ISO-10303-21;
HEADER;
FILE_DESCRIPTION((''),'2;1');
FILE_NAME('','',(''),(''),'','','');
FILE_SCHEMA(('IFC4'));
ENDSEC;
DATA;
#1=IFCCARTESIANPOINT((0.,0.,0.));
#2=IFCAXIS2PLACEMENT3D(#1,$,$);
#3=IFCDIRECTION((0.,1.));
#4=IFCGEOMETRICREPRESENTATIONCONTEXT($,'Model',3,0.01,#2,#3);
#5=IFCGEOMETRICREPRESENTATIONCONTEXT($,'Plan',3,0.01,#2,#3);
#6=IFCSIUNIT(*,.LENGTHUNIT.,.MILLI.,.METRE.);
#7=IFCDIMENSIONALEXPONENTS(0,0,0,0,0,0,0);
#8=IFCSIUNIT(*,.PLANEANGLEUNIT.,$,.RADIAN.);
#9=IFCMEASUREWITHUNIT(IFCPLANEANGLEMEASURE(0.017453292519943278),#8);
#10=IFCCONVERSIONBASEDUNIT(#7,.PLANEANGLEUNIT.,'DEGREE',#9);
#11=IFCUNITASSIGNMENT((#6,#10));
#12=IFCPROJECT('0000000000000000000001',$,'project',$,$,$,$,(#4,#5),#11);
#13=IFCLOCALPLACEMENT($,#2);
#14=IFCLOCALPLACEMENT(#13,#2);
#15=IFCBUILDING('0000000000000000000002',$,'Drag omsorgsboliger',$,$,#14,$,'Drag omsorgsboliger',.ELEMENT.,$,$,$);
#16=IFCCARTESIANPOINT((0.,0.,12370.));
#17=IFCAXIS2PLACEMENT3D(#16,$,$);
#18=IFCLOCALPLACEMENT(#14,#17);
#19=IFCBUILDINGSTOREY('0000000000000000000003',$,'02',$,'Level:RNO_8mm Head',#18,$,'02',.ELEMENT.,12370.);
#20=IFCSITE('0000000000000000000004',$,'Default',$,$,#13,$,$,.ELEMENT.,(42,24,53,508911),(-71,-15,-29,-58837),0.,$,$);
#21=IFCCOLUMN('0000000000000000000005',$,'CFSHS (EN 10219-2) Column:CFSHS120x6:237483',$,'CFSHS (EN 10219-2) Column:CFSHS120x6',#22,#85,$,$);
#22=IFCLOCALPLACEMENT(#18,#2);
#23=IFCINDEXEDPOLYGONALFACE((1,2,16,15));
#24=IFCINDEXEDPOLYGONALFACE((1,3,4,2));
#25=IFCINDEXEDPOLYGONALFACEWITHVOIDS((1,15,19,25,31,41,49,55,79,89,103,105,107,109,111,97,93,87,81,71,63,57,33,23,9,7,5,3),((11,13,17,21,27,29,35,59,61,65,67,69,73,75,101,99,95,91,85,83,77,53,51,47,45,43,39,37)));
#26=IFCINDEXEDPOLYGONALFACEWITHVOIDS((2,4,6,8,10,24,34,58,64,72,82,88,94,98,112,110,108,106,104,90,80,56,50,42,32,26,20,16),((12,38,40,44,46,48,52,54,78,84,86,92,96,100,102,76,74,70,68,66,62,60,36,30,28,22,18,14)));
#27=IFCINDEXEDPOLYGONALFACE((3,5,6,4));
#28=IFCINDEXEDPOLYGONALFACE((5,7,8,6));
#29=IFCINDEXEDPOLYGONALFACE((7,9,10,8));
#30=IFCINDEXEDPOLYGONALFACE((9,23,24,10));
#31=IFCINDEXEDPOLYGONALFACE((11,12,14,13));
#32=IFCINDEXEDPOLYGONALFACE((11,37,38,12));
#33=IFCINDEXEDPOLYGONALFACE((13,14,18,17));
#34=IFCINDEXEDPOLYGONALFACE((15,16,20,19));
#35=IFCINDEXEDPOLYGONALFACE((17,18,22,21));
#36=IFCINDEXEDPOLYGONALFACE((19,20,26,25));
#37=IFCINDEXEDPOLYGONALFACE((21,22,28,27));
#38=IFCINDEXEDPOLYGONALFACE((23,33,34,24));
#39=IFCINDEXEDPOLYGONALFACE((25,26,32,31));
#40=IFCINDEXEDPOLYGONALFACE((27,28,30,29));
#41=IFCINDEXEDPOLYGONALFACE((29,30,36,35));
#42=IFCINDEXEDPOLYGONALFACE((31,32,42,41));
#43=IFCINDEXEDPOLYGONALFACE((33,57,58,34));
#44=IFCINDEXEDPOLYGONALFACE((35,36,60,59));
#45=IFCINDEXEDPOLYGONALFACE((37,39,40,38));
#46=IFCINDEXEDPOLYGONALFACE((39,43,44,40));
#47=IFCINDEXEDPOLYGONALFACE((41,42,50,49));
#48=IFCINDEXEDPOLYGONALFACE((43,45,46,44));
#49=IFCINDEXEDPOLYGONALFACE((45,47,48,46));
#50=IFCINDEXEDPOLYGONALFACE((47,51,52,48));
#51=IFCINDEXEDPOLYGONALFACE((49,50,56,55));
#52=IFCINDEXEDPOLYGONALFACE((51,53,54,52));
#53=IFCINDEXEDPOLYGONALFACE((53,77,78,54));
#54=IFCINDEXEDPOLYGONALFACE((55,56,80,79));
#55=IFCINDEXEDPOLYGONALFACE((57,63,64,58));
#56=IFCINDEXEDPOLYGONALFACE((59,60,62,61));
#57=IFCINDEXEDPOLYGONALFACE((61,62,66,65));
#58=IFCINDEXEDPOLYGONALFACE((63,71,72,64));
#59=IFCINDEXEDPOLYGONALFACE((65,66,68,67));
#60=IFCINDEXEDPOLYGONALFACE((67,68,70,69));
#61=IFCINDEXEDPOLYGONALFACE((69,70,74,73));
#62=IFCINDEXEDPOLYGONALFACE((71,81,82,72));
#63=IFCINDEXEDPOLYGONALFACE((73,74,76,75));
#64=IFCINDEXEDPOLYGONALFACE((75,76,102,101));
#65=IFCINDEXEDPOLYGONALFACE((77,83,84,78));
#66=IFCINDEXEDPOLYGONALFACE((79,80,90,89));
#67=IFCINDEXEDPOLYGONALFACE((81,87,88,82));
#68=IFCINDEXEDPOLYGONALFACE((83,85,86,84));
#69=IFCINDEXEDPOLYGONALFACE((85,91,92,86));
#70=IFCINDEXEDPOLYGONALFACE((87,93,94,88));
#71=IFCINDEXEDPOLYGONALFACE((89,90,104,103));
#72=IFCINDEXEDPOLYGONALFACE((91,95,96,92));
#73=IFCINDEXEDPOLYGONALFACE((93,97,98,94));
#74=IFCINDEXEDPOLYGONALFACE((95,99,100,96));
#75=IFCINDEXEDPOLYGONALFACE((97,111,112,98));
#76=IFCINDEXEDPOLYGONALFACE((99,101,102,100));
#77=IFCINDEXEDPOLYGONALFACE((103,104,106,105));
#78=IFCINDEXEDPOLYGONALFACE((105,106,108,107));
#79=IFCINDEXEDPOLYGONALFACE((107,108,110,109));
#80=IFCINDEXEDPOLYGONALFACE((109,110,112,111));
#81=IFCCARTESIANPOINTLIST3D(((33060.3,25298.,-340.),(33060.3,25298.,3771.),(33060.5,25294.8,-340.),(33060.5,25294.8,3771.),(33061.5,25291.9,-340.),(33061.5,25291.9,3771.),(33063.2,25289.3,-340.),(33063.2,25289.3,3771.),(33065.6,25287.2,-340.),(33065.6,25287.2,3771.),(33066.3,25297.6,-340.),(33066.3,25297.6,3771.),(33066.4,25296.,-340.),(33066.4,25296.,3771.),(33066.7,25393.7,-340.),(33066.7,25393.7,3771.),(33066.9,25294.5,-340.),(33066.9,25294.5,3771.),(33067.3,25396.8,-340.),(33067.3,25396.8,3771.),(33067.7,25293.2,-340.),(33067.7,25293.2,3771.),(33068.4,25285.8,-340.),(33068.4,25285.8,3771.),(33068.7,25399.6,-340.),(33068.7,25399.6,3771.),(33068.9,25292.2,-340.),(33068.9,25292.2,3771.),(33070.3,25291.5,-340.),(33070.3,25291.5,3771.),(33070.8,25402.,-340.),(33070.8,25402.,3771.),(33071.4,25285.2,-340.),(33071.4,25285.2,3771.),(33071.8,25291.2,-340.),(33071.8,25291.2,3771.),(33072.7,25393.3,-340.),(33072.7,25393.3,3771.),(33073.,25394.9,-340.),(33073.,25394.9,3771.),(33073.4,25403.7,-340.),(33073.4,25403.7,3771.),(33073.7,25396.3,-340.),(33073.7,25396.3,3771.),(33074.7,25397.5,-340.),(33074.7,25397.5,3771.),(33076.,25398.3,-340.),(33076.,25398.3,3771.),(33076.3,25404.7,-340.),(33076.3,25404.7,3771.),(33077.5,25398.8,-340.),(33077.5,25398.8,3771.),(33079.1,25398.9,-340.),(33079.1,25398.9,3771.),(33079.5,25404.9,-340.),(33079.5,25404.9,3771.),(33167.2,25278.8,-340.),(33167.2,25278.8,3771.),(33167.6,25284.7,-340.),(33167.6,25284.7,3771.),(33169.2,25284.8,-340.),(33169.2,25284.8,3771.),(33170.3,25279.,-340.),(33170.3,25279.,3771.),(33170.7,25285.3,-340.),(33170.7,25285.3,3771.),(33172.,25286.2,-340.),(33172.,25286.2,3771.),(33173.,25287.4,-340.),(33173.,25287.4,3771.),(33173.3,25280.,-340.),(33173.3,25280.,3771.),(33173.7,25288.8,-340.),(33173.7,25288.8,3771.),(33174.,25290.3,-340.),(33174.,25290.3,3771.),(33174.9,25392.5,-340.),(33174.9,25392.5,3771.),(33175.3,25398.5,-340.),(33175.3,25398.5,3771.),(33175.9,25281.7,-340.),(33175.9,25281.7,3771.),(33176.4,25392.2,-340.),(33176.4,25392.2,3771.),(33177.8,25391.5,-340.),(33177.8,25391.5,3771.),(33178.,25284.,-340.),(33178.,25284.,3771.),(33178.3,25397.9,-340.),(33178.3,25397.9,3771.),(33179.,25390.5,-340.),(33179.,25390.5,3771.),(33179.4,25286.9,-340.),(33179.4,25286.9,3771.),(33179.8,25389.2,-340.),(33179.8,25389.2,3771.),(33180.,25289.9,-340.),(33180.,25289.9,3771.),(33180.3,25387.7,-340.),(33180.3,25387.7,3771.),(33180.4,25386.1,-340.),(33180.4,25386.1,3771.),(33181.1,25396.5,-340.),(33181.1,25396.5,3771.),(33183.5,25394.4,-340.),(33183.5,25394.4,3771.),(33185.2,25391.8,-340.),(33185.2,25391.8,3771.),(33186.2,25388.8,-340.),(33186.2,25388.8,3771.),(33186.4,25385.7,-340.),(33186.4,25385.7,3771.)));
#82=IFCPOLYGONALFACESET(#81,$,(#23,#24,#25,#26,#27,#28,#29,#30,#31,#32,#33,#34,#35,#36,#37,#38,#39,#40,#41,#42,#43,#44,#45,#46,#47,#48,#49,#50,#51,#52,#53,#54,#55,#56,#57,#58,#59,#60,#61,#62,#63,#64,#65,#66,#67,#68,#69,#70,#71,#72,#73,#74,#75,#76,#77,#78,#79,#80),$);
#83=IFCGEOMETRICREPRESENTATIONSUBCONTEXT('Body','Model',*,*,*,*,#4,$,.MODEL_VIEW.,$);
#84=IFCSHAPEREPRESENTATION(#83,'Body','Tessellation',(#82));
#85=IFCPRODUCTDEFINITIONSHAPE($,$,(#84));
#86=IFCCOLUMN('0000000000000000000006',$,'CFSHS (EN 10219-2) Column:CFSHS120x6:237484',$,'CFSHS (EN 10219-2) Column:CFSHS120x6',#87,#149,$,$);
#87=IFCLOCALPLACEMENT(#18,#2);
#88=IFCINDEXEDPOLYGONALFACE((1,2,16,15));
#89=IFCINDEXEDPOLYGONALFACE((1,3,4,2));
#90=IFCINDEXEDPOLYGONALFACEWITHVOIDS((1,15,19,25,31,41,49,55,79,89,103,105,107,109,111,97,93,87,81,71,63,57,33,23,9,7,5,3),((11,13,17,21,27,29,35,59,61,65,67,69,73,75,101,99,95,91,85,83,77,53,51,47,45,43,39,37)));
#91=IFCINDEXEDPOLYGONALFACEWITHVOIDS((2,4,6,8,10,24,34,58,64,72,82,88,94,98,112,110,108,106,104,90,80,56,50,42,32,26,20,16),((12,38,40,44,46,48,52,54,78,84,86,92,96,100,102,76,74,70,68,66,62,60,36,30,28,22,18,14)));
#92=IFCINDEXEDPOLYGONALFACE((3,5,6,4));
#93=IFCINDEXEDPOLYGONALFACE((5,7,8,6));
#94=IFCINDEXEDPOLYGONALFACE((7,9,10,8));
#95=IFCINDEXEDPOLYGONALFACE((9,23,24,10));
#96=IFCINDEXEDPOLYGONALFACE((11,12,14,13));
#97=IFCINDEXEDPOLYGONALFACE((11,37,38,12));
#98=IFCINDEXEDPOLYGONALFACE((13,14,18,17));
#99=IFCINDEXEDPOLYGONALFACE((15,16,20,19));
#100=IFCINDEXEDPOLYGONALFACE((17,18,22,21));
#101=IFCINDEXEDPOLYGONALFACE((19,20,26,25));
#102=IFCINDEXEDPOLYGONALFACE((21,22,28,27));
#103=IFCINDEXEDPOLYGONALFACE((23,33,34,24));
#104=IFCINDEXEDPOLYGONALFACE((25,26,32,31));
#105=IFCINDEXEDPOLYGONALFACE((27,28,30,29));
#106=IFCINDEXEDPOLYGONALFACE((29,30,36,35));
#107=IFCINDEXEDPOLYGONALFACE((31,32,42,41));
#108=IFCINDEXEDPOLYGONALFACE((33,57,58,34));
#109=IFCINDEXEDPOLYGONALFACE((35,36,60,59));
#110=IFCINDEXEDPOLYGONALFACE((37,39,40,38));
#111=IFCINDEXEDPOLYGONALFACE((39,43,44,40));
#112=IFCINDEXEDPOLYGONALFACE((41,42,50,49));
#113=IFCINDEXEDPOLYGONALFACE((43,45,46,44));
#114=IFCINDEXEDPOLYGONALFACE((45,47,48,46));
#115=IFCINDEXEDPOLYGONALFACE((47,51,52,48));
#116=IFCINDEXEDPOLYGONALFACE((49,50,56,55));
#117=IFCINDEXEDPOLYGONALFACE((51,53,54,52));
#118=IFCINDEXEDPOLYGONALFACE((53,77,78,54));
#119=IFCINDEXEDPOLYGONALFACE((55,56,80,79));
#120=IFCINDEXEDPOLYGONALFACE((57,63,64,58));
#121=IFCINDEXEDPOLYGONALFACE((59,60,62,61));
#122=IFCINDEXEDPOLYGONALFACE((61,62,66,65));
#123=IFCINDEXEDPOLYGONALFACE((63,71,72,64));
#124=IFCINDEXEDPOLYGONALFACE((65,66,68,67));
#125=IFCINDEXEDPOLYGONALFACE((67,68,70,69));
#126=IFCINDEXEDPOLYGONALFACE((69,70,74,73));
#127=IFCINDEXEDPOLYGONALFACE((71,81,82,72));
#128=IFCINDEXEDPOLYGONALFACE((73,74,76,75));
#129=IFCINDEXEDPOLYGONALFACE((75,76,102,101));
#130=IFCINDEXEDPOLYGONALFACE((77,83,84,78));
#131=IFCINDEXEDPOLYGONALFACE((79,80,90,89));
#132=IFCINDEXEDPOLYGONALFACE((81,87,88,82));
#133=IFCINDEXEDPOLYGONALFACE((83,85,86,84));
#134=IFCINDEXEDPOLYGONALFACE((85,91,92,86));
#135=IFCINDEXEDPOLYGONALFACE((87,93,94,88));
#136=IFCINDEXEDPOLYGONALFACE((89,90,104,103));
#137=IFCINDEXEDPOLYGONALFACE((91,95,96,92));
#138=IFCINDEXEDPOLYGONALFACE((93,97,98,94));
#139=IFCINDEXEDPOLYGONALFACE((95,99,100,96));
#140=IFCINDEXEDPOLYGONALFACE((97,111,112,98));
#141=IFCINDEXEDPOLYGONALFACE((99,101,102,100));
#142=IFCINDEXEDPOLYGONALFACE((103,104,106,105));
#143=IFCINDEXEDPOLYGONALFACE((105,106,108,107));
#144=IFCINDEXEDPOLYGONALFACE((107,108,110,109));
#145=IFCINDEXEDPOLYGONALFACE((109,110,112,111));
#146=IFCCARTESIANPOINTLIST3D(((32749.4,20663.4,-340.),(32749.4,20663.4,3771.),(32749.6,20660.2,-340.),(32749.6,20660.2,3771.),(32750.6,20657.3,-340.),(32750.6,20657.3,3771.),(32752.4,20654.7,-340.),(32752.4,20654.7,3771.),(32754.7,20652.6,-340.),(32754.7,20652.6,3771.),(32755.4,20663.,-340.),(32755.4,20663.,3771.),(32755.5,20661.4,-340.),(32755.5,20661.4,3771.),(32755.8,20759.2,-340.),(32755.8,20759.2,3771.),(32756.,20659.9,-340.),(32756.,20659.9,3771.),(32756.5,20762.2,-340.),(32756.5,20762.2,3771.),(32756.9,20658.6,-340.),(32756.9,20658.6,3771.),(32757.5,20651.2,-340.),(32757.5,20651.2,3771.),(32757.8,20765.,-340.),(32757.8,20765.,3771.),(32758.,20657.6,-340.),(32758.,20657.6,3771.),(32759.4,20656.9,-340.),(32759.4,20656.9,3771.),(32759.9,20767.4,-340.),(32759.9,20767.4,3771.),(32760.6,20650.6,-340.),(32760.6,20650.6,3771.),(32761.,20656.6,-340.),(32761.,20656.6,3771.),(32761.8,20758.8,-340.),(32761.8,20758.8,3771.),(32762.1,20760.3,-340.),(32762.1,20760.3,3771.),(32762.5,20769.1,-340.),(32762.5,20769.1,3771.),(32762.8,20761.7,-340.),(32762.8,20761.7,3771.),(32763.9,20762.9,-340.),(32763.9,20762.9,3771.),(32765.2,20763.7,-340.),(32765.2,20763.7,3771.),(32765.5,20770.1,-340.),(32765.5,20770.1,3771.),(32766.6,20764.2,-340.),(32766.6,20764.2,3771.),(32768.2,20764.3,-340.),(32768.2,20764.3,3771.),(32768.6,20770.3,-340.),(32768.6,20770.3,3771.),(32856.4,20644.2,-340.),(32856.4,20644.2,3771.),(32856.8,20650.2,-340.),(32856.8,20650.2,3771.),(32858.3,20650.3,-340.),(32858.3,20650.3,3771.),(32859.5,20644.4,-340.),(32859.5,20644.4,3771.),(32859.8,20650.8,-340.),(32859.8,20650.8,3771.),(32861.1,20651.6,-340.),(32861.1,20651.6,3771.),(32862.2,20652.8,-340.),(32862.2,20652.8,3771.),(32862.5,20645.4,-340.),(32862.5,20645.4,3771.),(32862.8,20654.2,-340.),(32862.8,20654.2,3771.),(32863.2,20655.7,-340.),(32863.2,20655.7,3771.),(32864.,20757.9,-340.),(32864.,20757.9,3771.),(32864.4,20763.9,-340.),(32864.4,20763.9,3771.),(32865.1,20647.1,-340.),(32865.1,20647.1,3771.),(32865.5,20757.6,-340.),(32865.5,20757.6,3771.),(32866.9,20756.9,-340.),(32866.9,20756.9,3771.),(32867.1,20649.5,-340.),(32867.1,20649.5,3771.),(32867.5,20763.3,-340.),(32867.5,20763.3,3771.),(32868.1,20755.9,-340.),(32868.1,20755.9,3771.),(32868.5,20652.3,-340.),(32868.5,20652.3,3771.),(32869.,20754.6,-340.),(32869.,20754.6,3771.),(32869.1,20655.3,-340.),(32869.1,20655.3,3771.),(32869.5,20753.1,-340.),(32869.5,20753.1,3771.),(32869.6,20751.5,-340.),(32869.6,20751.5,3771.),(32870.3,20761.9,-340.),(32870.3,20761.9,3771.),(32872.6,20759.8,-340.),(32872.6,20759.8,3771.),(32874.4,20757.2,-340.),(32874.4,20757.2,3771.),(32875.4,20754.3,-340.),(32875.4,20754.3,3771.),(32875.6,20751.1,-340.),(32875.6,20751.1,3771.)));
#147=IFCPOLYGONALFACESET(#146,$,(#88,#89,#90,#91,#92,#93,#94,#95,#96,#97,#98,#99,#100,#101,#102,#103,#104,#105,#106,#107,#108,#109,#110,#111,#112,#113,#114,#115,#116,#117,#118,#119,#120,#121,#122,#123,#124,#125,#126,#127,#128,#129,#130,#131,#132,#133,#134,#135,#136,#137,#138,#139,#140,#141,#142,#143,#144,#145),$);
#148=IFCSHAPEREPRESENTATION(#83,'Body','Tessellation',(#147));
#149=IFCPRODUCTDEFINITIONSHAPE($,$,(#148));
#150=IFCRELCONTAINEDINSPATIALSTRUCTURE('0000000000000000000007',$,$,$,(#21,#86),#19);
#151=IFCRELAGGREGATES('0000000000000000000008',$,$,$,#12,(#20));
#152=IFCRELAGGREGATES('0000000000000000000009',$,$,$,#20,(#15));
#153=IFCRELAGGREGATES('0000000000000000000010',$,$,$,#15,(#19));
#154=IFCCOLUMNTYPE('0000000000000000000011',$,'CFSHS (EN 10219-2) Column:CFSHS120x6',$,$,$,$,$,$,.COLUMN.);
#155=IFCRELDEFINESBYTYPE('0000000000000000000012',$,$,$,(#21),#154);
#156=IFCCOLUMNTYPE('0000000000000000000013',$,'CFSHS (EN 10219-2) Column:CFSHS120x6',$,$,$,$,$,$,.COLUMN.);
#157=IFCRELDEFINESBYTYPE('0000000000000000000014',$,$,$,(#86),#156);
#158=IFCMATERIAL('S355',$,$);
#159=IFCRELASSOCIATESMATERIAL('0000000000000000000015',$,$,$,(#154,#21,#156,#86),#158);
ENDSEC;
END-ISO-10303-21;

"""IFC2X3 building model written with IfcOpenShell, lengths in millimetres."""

from ifc_helpers import new_model, entity, si_unit, converted_unit, direction, frame, frame_2d, origin, place, context, subcontext, project, spatial, polyline, circle_curve, parameter, trimmed, segment, composite_curve, outline, extrude, source, transform, mapped, material, type_object, type_shapes, element, save


model = new_model("IFC2X3")

# Units and contexts
model_context = context("Model", 3, precision=0.01, world=origin(), true_north=direction((0.0, 1.0)))
plan_context = context("Plan", 3, precision=0.01, world=origin(), true_north=direction((0.0, 1.0)))
body_context = subcontext(model_context, "Body", "Model", "MODEL_VIEW")
ifc_project = project(units=[si_unit("LENGTHUNIT", "METRE", prefix="MILLI"), converted_unit("PLANEANGLEUNIT", "DEGREE", entity("IfcPlaneAngleMeasure", 0.017453292519943278), si_unit("PLANEANGLEUNIT", "RADIAN"), dimensions=[0, 0, 0, 0, 0, 0, 0])], contexts=[model_context, plan_context])

# Site, building, storey
site_placement = place(None, origin())
site = spatial("IfcSite", under=ifc_project, at=site_placement, Name="Default", CompositionType="ELEMENT", RefLatitude=(42, 24, 53, 508911), RefLongitude=(-71, -15, -29, -58837), RefElevation=0.0)
building_placement = place(site_placement, origin())
building = spatial("IfcBuilding", under=site, at=building_placement, Name="Drag omsorgsboliger", LongName="Drag omsorgsboliger", CompositionType="ELEMENT")
storey_placement = place(building_placement, frame((0.0, 0.0, 12370.0)))
storey = spatial("IfcBuildingStorey", under=building, at=storey_placement, Name="02", ObjectType="Level:RNO_8mm Head", LongName="02", CompositionType="ELEMENT", Elevation=12370.0)

# Columns
ifc_material = material(Name="S355")
column_type_1 = type_object("IfcColumnType", Name="CFSHS (EN 10219-2) Column:CFSHS120x6", PredefinedType="COLUMN", material=ifc_material)
shared_shape_1 = source(origin(), body_context, "Body", "SweptSolid", [
    extrude(outline(composite_curve([segment(polyline([(-48.0, -60.0), (48.0, -60.0)]), True, "CONTINUOUS"), segment(trimmed(circle_curve(frame_2d((48.0, -48.0), x_axis=(-1.0, 0.0)), 12.0), [parameter(90.0)], [parameter(180.0)], True, "PARAMETER"), True, "CONTINUOUS"), segment(polyline([(60.0, -48.0), (60.0, 48.0)]), True, "CONTINUOUS"), segment(trimmed(circle_curve(frame_2d((48.0, 48.0), x_axis=(-1.0, 0.0)), 12.0), [parameter(180.0)], [parameter(270.0)], True, "PARAMETER"), True, "CONTINUOUS"), segment(polyline([(48.0, 60.0), (-48.0, 60.0)]), True, "CONTINUOUS"), segment(trimmed(circle_curve(frame_2d((-48.0, 48.0), x_axis=(-1.0, 0.0)), 12.0), [parameter(270.0)], [parameter(360.0)], True, "PARAMETER"), True, "CONTINUOUS"), segment(polyline([(-60.0, 48.0), (-60.0, -48.0)]), True, "CONTINUOUS"), segment(trimmed(circle_curve(frame_2d((-48.0, -48.0), x_axis=(-1.0, 0.0)), 12.0), [parameter(360.0)], [parameter(90.0)], True, "PARAMETER"), True, "CONTINUOUS")], self_intersect=False), holes=[composite_curve([segment(trimmed(circle_curve(frame_2d((-48.0, -48.0), x_axis=(-1.0, 0.0)), 6.0), [parameter(360.0)], [parameter(90.0)], True, "PARAMETER"), False, "CONTINUOUS"), segment(polyline([(-54.0, -48.0), (-54.0, 48.0)]), True, "CONTINUOUS"), segment(trimmed(circle_curve(frame_2d((-48.0, 48.0), x_axis=(-1.0, 0.0)), 6.0), [parameter(270.0)], [parameter(360.0)], True, "PARAMETER"), False, "CONTINUOUS"), segment(polyline([(-48.0, 54.0), (48.0, 54.0)]), True, "CONTINUOUS"), segment(trimmed(circle_curve(frame_2d((48.0, 48.0), x_axis=(-1.0, 0.0)), 6.0), [parameter(180.0)], [parameter(270.0)], True, "PARAMETER"), False, "CONTINUOUS"), segment(polyline([(54.0, 48.0), (54.0, -48.0)]), True, "CONTINUOUS"), segment(trimmed(circle_curve(frame_2d((48.0, -48.0), x_axis=(-1.0, 0.0)), 6.0), [parameter(90.0)], [parameter(180.0)], True, "PARAMETER"), False, "CONTINUOUS"), segment(polyline([(48.0, -54.0), (-48.0, -54.0)]), True, "CONTINUOUS")], self_intersect=False)]), frame((33123.3, 25341.8, 12030.0), z_axis=(0.0, 0.0, 1.0), x_axis=(-0.997758, 0.066923, 0.0)), (0.0, 0.0, 1.0), 4111.0),
])
type_shapes(column_type_1, [shared_shape_1])
column_1_placement = place(storey_placement, frame((0.0, 0.0, -12370.0)))
element("IfcColumn", 1, at=column_1_placement, inside=storey, type_object=column_type_1, material=ifc_material, Name="CFSHS (EN 10219-2) Column:CFSHS120x6:237483", ObjectType="CFSHS (EN 10219-2) Column:CFSHS120x6", context=body_context, shape_type="MappedRepresentation", body=[
    mapped(shared_shape_1, transform((0.0, 0.0, 0.0), scale=1.0)),
])
column_type_2 = type_object("IfcColumnType", Name="CFSHS (EN 10219-2) Column:CFSHS120x6", PredefinedType="COLUMN", material=ifc_material)
shared_shape_2 = source(origin(), body_context, "Body", "SweptSolid", [
    extrude(outline(composite_curve([segment(polyline([(-48.0, -60.0), (48.0, -60.0)]), True, "CONTINUOUS"), segment(trimmed(circle_curve(frame_2d((48.0, -48.0), x_axis=(-1.0, 0.0)), 12.0), [parameter(90.0)], [parameter(180.0)], True, "PARAMETER"), True, "CONTINUOUS"), segment(polyline([(60.0, -48.0), (60.0, 48.0)]), True, "CONTINUOUS"), segment(trimmed(circle_curve(frame_2d((48.0, 48.0), x_axis=(-1.0, 0.0)), 12.0), [parameter(180.0)], [parameter(270.0)], True, "PARAMETER"), True, "CONTINUOUS"), segment(polyline([(48.0, 60.0), (-48.0, 60.0)]), True, "CONTINUOUS"), segment(trimmed(circle_curve(frame_2d((-48.0, 48.0), x_axis=(-1.0, 0.0)), 12.0), [parameter(270.0)], [parameter(360.0)], True, "PARAMETER"), True, "CONTINUOUS"), segment(polyline([(-60.0, 48.0), (-60.0, -48.0)]), True, "CONTINUOUS"), segment(trimmed(circle_curve(frame_2d((-48.0, -48.0), x_axis=(-1.0, 0.0)), 12.0), [parameter(360.0)], [parameter(90.0)], True, "PARAMETER"), True, "CONTINUOUS")], self_intersect=False), holes=[composite_curve([segment(trimmed(circle_curve(frame_2d((-48.0, -48.0), x_axis=(-1.0, 0.0)), 6.0), [parameter(360.0)], [parameter(90.0)], True, "PARAMETER"), False, "CONTINUOUS"), segment(polyline([(-54.0, -48.0), (-54.0, 48.0)]), True, "CONTINUOUS"), segment(trimmed(circle_curve(frame_2d((-48.0, 48.0), x_axis=(-1.0, 0.0)), 6.0), [parameter(270.0)], [parameter(360.0)], True, "PARAMETER"), False, "CONTINUOUS"), segment(polyline([(-48.0, 54.0), (48.0, 54.0)]), True, "CONTINUOUS"), segment(trimmed(circle_curve(frame_2d((48.0, 48.0), x_axis=(-1.0, 0.0)), 6.0), [parameter(180.0)], [parameter(270.0)], True, "PARAMETER"), False, "CONTINUOUS"), segment(polyline([(54.0, 48.0), (54.0, -48.0)]), True, "CONTINUOUS"), segment(trimmed(circle_curve(frame_2d((48.0, -48.0), x_axis=(-1.0, 0.0)), 6.0), [parameter(90.0)], [parameter(180.0)], True, "PARAMETER"), False, "CONTINUOUS"), segment(polyline([(48.0, -54.0), (-48.0, -54.0)]), True, "CONTINUOUS")], self_intersect=False)]), frame((32812.5, 20707.2, 12030.0), z_axis=(0.0, 0.0, 1.0), x_axis=(-0.997758, 0.066923, 0.0)), (0.0, 0.0, 1.0), 4111.0),
])
type_shapes(column_type_2, [shared_shape_2])
column_2_placement = place(storey_placement, frame((0.0, 0.0, -12370.0)))
element("IfcColumn", 2, at=column_2_placement, inside=storey, type_object=column_type_2, material=ifc_material, Name="CFSHS (EN 10219-2) Column:CFSHS120x6:237484", ObjectType="CFSHS (EN 10219-2) Column:CFSHS120x6", context=body_context, shape_type="MappedRepresentation", body=[
    mapped(shared_shape_2, transform((0.0, 0.0, 0.0), scale=1.0)),
])

save(model, "model.ifc")
